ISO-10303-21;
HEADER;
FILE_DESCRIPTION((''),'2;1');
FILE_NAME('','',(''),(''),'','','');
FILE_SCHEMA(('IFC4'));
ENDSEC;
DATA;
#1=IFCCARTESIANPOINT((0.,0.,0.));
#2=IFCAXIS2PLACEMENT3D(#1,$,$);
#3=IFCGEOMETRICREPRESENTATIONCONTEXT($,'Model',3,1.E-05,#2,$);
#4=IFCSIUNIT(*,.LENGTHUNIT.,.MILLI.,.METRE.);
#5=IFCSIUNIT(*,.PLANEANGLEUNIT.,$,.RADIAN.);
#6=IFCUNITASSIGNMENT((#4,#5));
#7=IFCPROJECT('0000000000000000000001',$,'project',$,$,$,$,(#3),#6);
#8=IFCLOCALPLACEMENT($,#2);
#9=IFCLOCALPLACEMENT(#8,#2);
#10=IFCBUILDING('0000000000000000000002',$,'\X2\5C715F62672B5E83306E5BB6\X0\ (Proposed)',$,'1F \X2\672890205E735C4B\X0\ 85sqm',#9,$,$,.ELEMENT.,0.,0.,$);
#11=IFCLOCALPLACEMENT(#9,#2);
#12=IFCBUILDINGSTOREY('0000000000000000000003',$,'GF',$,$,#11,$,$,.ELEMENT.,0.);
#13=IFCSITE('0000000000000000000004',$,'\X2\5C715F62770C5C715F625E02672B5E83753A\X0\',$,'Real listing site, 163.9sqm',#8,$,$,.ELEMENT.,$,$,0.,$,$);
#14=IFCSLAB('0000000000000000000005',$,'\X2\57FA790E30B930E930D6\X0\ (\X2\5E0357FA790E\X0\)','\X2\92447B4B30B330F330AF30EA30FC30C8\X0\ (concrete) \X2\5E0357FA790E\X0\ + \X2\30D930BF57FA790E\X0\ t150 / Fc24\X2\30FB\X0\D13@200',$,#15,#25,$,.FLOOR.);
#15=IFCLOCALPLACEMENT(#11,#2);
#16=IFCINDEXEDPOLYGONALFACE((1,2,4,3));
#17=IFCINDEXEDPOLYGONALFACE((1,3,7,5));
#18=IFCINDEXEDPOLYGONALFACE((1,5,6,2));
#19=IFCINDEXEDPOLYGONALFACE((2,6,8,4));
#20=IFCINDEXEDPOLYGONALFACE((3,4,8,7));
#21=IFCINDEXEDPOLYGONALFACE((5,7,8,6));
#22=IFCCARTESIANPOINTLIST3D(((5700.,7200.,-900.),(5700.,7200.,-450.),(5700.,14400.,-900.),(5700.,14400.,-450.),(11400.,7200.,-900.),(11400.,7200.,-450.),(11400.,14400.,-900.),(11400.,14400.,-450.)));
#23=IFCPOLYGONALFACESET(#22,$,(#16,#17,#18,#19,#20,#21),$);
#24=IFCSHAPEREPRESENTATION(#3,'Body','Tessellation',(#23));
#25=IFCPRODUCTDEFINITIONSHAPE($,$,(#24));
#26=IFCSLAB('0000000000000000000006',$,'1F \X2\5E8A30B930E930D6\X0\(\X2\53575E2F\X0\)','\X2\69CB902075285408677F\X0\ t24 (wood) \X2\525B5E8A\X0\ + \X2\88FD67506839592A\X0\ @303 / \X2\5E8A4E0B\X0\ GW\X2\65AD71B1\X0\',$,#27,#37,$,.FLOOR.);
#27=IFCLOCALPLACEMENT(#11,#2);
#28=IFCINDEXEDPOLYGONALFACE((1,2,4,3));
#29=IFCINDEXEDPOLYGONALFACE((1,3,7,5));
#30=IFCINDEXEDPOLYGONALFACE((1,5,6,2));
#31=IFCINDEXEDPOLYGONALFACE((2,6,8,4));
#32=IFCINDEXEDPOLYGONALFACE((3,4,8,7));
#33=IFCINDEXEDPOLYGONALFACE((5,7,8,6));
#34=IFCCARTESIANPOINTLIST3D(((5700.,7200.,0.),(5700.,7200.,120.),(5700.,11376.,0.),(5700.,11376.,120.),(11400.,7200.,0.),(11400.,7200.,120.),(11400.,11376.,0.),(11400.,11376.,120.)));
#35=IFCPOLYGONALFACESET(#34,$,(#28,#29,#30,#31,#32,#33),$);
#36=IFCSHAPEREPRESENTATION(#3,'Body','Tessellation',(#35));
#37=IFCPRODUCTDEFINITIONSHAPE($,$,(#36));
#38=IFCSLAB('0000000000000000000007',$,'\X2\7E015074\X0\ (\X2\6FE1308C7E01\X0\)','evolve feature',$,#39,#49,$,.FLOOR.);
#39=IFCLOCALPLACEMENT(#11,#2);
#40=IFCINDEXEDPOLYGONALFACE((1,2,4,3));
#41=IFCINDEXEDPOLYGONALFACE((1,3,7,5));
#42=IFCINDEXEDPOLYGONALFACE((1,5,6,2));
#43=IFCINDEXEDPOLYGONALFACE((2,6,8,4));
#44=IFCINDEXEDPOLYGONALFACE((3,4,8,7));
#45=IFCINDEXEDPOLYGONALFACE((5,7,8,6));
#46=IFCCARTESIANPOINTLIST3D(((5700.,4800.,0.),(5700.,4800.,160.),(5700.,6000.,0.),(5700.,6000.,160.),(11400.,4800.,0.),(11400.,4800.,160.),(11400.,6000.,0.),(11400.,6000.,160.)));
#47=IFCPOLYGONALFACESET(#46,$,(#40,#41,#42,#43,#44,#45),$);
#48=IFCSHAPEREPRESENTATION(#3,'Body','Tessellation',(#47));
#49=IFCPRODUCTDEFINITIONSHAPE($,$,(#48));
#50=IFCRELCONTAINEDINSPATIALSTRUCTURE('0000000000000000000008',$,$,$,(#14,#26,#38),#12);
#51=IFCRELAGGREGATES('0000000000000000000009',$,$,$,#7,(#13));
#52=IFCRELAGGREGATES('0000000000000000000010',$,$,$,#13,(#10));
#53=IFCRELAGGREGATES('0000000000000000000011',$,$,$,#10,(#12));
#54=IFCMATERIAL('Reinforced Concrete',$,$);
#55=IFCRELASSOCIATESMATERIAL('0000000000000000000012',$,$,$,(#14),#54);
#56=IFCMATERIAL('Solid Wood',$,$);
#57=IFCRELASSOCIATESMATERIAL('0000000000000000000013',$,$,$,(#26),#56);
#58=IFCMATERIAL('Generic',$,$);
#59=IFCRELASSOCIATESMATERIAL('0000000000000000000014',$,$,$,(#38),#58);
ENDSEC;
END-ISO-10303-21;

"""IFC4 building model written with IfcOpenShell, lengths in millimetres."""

from ifc_helpers import new_model, si_unit, frame, frame_2d, origin, place, context, project, spatial, rectangle, extrude, material, element, save


model = new_model("IFC4")

# Units and contexts
model_context = context("Model", 3, precision=1e-05, world=origin())
ifc_project = project(units=[si_unit("LENGTHUNIT", "METRE", prefix="MILLI"), si_unit("PLANEANGLEUNIT", "RADIAN")], contexts=[model_context])

# Site, building, storey
site_placement = place(None, origin())
site = spatial("IfcSite", under=ifc_project, at=site_placement, Name="山形県山形市末広町", ObjectType="Real listing site, 163.9sqm", CompositionType="ELEMENT", RefElevation=0.0)
building_placement = place(site_placement, origin())
building = spatial("IfcBuilding", under=site, at=building_placement, Name="山形末広の家 (Proposed)", ObjectType="1F 木造平屋 85sqm", CompositionType="ELEMENT", ElevationOfRefHeight=0.0, ElevationOfTerrain=0.0)
storey_placement = place(building_placement, origin())
storey = spatial("IfcBuildingStorey", under=building, at=storey_placement, Name="GF", CompositionType="ELEMENT", Elevation=0.0)

# Slabs
ifc_material_1 = material(Name="Reinforced Concrete")
slab_1_placement = place(storey_placement, frame((2850.0, 3600.0, -450.0)))
element("IfcSlab", 1, at=slab_1_placement, inside=storey, material=ifc_material_1, Name="基礎スラブ (布基礎)", Description="鉄筋コンクリート (concrete) 布基礎 + ベタ基礎 t150 / Fc24・D13@200", PredefinedType="FLOOR", context=model_context, shape_type="SweptSolid", body=[
    extrude(rectangle(XDim=5700.0, YDim=7200.0, at=frame_2d((2850.0, 3600.0))), frame((2850.0, 3600.0, -450.0)), (0.0, 0.0, 1.0), 450.0),
])
ifc_material_2 = material(Name="Solid Wood")
slab_2_placement = place(storey_placement, frame((2850.0, 3600.0, 0.0)))
element("IfcSlab", 2, at=slab_2_placement, inside=storey, material=ifc_material_2, Name="1F 床スラブ(南帯)", Description="構造用合板 t24 (wood) 剛床 + 製材根太 @303 / 床下 GW断熱", PredefinedType="FLOOR", context=model_context, shape_type="SweptSolid", body=[
    extrude(rectangle(XDim=5700.0, YDim=4176.0, at=frame_2d((2850.0, 2088.0))), frame((2850.0, 3600.0, 0.0)), (0.0, 0.0, 1.0), 120.0),
])
ifc_material_3 = material(Name="Generic")
slab_3_placement = place(storey_placement, frame((2850.0, 2400.0, 0.0)))
element("IfcSlab", 3, at=slab_3_placement, inside=storey, material=ifc_material_3, Name="縁側 (濡れ縁)", Description="evolve feature", PredefinedType="FLOOR", context=model_context, shape_type="SweptSolid", body=[
    extrude(rectangle(XDim=5700.0, YDim=1200.0, at=frame_2d((2850.0, 600.0))), frame((2850.0, 2400.0, 0.0)), (0.0, 0.0, 1.0), 160.0),
])

save(model, "model.ifc")
